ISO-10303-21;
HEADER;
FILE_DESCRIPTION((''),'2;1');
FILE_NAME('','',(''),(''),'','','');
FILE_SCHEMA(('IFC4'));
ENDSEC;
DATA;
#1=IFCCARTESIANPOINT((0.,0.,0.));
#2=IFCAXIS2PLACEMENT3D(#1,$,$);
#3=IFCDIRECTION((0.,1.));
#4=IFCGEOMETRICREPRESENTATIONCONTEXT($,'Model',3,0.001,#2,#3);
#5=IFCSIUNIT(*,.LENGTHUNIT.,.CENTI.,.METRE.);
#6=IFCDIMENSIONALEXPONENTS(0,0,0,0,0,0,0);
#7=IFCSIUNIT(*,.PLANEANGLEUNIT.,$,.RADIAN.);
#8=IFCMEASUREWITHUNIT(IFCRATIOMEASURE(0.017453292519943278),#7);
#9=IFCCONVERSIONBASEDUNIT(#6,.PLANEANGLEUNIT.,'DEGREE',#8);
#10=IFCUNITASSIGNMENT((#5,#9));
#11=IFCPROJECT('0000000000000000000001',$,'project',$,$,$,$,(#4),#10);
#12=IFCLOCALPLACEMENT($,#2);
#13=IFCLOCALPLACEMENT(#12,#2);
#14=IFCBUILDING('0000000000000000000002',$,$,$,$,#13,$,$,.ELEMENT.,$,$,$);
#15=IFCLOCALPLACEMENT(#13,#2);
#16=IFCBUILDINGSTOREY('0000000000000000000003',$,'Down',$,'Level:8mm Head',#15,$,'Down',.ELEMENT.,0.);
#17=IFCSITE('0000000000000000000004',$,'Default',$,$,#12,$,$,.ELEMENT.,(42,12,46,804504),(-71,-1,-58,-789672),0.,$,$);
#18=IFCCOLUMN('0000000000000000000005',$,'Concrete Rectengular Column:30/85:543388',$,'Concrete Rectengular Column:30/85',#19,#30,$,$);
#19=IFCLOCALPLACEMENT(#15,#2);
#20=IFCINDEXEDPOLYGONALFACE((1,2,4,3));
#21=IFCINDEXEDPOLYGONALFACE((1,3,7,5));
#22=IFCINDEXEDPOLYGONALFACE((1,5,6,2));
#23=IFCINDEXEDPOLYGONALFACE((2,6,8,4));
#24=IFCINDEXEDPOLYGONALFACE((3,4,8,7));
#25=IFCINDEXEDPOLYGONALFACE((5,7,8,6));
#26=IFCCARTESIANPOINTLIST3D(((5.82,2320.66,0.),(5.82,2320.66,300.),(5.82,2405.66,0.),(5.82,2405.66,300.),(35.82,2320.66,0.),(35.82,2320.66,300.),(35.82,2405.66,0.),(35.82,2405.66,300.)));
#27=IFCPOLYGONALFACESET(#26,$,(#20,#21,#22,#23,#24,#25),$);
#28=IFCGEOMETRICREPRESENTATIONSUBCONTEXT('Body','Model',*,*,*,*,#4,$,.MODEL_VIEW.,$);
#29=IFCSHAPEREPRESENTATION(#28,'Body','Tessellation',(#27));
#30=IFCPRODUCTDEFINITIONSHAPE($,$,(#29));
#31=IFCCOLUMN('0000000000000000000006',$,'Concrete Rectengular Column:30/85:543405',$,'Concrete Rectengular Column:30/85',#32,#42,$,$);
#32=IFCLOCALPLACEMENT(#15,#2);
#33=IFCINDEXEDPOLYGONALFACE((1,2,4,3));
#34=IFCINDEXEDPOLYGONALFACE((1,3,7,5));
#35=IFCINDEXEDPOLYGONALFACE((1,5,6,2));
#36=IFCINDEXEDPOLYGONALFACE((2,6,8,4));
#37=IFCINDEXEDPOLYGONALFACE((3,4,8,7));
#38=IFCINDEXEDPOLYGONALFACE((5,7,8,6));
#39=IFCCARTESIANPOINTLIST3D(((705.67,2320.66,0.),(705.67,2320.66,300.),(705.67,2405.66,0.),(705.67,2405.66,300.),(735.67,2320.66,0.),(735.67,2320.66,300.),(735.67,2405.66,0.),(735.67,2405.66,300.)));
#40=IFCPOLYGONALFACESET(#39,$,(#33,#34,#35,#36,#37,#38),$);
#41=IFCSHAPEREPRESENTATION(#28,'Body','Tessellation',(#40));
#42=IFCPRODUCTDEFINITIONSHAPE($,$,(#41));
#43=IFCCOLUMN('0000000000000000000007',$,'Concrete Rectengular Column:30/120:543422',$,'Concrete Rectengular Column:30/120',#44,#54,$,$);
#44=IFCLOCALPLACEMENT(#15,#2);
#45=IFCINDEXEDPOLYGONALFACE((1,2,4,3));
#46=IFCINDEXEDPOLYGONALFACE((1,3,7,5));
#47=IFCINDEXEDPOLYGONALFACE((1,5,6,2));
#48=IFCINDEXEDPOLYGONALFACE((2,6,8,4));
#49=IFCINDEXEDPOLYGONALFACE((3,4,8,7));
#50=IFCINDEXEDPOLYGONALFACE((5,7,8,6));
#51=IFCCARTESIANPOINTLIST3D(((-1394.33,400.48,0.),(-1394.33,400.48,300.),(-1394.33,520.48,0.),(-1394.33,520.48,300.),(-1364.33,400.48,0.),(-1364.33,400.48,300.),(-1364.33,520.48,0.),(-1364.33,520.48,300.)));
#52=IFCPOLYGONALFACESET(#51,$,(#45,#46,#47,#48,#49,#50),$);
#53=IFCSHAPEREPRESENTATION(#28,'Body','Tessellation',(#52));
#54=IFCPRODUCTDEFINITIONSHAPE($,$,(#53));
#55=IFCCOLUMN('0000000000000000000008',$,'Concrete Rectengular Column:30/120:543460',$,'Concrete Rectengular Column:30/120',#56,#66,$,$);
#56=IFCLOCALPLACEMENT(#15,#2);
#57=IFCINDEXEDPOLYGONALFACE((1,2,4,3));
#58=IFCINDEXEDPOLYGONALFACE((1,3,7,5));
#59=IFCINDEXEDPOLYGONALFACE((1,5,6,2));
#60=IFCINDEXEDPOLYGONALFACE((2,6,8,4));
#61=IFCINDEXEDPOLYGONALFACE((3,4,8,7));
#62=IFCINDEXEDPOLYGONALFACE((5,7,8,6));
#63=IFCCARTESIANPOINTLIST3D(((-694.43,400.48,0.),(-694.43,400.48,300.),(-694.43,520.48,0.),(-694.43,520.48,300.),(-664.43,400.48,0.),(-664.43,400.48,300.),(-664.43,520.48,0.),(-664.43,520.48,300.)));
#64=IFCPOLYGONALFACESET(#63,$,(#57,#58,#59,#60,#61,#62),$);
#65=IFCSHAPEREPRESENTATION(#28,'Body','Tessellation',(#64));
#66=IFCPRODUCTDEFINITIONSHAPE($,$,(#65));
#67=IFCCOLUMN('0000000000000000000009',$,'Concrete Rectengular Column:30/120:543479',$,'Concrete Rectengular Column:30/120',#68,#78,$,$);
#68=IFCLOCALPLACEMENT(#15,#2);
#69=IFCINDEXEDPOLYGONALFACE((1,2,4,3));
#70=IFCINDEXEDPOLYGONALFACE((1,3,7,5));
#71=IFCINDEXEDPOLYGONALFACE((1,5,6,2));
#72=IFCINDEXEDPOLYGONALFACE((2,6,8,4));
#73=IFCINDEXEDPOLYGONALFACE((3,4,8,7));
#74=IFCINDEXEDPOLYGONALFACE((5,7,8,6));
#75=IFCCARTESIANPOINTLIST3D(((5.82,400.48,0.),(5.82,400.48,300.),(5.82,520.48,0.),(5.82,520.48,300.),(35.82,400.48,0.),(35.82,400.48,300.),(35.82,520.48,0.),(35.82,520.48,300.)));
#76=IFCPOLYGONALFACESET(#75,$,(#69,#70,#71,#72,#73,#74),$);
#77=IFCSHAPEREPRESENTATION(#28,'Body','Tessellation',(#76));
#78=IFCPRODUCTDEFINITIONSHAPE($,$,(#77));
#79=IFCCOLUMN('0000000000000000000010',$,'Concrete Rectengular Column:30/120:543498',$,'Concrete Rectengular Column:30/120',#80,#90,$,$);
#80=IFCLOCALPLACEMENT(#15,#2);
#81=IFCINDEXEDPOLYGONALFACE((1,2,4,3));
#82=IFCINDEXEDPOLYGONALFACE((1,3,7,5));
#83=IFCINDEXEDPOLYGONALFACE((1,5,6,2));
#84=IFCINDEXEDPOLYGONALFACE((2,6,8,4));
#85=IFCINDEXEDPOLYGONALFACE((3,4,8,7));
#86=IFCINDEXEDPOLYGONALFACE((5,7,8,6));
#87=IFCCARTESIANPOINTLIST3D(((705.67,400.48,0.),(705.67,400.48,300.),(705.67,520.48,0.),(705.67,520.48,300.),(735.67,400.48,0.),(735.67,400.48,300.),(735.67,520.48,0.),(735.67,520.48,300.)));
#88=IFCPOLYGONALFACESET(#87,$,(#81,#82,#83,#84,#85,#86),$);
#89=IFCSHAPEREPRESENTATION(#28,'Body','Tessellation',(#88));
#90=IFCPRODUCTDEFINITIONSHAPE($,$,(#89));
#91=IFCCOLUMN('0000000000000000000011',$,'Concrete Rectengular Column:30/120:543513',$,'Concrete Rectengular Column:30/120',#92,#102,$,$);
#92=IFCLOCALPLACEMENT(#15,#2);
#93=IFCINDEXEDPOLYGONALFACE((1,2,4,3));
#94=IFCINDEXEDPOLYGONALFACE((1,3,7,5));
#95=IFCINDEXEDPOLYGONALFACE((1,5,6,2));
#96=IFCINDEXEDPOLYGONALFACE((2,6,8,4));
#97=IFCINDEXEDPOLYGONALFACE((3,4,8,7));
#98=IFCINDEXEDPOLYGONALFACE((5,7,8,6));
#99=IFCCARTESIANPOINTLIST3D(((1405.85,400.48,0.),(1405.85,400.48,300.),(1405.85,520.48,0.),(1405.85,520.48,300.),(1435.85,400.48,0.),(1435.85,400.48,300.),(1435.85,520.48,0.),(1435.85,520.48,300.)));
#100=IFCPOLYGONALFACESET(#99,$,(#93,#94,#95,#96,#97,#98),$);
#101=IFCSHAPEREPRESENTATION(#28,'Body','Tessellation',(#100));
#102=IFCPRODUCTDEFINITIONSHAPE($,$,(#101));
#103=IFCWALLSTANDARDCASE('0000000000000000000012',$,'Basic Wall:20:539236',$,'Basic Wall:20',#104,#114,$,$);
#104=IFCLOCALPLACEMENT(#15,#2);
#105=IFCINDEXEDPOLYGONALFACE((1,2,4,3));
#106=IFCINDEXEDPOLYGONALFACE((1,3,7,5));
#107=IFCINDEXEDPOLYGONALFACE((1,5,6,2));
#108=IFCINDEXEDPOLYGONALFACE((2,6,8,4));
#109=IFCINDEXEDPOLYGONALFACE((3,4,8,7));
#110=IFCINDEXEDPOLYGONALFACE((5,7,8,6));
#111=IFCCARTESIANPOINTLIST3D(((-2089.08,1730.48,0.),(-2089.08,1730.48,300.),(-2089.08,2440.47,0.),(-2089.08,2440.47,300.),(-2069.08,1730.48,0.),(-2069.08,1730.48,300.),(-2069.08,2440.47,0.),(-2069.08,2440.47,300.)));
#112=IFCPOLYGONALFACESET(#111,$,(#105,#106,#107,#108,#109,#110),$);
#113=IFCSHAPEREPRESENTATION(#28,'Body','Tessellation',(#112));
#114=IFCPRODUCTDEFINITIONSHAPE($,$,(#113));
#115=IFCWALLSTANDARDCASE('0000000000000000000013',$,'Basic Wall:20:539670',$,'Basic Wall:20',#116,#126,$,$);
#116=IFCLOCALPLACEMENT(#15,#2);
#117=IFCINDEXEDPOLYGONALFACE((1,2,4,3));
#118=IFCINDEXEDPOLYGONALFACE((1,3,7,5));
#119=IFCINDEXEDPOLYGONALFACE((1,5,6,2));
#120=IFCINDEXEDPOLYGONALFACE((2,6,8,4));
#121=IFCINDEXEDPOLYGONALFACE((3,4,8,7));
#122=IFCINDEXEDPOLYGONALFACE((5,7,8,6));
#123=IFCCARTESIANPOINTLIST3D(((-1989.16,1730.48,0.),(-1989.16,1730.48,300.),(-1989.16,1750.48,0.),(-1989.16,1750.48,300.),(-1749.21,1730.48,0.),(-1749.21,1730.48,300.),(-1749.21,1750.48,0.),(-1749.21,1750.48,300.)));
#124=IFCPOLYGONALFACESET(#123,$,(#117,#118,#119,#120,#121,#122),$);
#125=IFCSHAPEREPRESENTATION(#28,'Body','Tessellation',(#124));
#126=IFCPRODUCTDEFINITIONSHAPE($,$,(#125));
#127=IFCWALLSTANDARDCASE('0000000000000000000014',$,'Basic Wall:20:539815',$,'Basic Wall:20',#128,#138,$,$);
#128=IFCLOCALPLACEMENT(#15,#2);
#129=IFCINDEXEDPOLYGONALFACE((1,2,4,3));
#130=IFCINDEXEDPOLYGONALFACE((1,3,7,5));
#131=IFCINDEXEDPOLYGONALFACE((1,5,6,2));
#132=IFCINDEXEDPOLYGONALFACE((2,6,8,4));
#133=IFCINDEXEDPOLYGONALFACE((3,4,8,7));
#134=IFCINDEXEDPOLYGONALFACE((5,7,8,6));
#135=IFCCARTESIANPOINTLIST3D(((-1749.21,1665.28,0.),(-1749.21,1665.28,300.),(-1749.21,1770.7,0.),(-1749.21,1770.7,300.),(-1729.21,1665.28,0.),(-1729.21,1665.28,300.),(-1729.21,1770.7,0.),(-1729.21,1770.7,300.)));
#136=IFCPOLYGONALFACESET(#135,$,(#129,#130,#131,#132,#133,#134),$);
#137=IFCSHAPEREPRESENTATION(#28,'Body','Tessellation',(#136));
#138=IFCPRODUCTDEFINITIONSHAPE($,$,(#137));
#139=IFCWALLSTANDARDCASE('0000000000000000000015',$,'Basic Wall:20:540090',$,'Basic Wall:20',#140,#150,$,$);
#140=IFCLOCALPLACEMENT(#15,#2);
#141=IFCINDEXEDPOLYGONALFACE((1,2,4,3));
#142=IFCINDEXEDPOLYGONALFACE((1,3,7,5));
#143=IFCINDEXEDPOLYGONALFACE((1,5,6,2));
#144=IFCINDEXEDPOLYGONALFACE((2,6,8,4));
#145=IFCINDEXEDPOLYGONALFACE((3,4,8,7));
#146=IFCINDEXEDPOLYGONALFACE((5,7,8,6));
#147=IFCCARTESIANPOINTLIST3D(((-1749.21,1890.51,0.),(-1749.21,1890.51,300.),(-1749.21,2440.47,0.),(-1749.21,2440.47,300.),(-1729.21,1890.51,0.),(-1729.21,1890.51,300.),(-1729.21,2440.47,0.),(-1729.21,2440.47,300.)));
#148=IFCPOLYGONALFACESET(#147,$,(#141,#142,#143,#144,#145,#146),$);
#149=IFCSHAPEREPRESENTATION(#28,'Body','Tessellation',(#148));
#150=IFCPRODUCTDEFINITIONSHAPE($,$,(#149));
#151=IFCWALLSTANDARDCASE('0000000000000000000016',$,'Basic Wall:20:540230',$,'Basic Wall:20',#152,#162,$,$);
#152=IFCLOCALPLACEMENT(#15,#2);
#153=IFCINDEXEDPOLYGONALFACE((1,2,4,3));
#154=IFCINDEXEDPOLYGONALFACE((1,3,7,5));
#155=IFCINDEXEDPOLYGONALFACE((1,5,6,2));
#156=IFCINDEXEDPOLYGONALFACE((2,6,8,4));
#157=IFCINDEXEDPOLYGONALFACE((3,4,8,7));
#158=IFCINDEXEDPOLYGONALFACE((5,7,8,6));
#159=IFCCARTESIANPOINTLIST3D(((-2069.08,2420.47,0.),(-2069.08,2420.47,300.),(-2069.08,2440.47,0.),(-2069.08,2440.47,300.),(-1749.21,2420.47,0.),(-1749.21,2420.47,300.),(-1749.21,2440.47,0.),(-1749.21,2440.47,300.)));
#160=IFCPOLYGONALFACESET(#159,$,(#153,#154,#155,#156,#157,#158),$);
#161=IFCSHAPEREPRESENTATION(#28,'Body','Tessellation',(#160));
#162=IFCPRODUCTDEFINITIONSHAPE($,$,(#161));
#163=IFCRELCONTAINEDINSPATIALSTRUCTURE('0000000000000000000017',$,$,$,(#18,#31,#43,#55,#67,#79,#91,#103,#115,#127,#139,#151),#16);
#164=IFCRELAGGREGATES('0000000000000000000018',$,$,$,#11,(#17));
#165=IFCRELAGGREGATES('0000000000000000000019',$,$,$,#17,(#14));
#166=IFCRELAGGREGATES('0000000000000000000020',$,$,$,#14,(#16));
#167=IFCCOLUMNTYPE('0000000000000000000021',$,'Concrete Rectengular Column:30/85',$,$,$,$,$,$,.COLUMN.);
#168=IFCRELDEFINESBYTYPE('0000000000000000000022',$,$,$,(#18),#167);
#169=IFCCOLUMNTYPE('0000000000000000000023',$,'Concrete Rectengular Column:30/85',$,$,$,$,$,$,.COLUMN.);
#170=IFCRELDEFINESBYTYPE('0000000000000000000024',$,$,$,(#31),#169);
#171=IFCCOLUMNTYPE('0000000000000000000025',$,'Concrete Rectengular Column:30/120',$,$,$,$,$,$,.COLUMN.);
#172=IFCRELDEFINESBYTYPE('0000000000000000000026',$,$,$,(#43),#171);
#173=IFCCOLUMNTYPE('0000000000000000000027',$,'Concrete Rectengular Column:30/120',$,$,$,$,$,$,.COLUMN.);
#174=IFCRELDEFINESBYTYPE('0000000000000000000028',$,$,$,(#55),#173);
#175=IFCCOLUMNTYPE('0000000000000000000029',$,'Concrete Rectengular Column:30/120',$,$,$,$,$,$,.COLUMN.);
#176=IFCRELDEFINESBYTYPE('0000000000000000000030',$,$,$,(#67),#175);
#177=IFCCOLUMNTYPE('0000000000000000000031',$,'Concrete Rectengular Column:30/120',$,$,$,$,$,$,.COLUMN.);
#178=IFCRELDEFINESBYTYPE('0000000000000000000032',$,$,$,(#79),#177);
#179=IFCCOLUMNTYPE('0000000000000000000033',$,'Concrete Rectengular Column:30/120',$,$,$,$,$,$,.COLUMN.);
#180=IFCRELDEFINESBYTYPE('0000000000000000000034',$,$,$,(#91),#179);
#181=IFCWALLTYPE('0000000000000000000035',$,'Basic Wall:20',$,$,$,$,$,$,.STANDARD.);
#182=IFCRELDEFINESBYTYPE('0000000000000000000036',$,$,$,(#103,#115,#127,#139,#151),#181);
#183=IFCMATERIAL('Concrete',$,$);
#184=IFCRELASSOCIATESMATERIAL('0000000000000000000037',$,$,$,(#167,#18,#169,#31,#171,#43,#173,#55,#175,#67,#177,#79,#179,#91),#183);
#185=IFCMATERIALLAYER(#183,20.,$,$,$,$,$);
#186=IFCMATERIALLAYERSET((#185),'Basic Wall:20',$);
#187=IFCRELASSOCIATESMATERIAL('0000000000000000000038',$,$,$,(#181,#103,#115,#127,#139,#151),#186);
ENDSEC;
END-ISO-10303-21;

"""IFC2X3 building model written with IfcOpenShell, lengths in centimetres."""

from ifc_helpers import new_model, entity, si_unit, converted_unit, direction, frame, frame_2d, origin, origin_2d_with_axis, place, context, subcontext, project, spatial, rectangle, extrude, source, transform, mapped, material, layer, layer_set, layer_usage, type_object, type_shapes, element, save


model = new_model("IFC2X3")

# Units and contexts
model_context = context("Model", 3, precision=0.001, world=origin(), true_north=direction((0.0, 1.0)))
body_context = subcontext(model_context, "Body", "Model", "MODEL_VIEW")
ifc_project = project(units=[si_unit("LENGTHUNIT", "METRE", prefix="CENTI"), converted_unit("PLANEANGLEUNIT", "DEGREE", entity("IfcRatioMeasure", 0.017453292519943278), si_unit("PLANEANGLEUNIT", "RADIAN"), dimensions=[0, 0, 0, 0, 0, 0, 0])], contexts=[model_context])

# Site, building, storey
site_placement = place(None, origin())
site = spatial("IfcSite", under=ifc_project, at=site_placement, Name="Default", CompositionType="ELEMENT", RefLatitude=(42, 12, 46, 804504), RefLongitude=(-71, -1, -58, -789672), RefElevation=0.0)
building_placement = place(site_placement, origin())
building = spatial("IfcBuilding", under=site, at=building_placement, CompositionType="ELEMENT")
storey_placement = place(building_placement, origin())
storey = spatial("IfcBuildingStorey", under=building, at=storey_placement, Name="Down", ObjectType="Level:8mm Head", LongName="Down", CompositionType="ELEMENT", Elevation=0.0)

# Columns
ifc_material = material(Name="Concrete")
column_type_1 = type_object("IfcColumnType", Name="Concrete Rectengular Column:30/85", PredefinedType="COLUMN", material=ifc_material)
shared_shape_1 = source(origin(), body_context, "Body", "SweptSolid", [
    extrude(rectangle(XDim=85.0, YDim=30.0, at=frame_2d((0.0, 0.0), x_axis=(1.0, 0.0))), frame((20.82, 2363.16, 0.0), z_axis=(0.0, 0.0, 1.0), x_axis=(0.0, -1.0, 0.0)), (0.0, 0.0, 1.0), 300.0),
])
type_shapes(column_type_1, [shared_shape_1])
column_1_placement = place(storey_placement, origin())
element("IfcColumn", 1, at=column_1_placement, inside=storey, type_object=column_type_1, material=ifc_material, Name="Concrete Rectengular Column:30/85:543388", ObjectType="Concrete Rectengular Column:30/85", context=body_context, shape_type="MappedRepresentation", body=[
    mapped(shared_shape_1, transform((0.0, 0.0, 0.0), scale=1.0)),
])
column_type_2 = type_object("IfcColumnType", Name="Concrete Rectengular Column:30/85", PredefinedType="COLUMN", material=ifc_material)
shared_shape_2 = source(origin(), body_context, "Body", "SweptSolid", [
    extrude(rectangle(XDim=85.0, YDim=30.0, at=frame_2d((0.0, 0.0), x_axis=(1.0, 0.0))), frame((720.67, 2363.16, 0.0), z_axis=(0.0, 0.0, 1.0), x_axis=(0.0, -1.0, 0.0)), (0.0, 0.0, 1.0), 300.0),
])
type_shapes(column_type_2, [shared_shape_2])
column_2_placement = place(storey_placement, origin())
element("IfcColumn", 2, at=column_2_placement, inside=storey, type_object=column_type_2, material=ifc_material, Name="Concrete Rectengular Column:30/85:543405", ObjectType="Concrete Rectengular Column:30/85", context=body_context, shape_type="MappedRepresentation", body=[
    mapped(shared_shape_2, transform((0.0, 0.0, 0.0), scale=1.0)),
])
column_type_3 = type_object("IfcColumnType", Name="Concrete Rectengular Column:30/120", PredefinedType="COLUMN", material=ifc_material)
shared_shape_3 = source(origin(), body_context, "Body", "SweptSolid", [
    extrude(rectangle(XDim=120.0, YDim=30.0, at=origin_2d_with_axis()), frame((-1379.33, 460.48, 0.0), z_axis=(0.0, 0.0, 1.0), x_axis=(0.0, -1.0, 0.0)), (0.0, 0.0, 1.0), 300.0),
])
type_shapes(column_type_3, [shared_shape_3])
column_3_placement = place(storey_placement, origin())
element("IfcColumn", 3, at=column_3_placement, inside=storey, type_object=column_type_3, material=ifc_material, Name="Concrete Rectengular Column:30/120:543422", ObjectType="Concrete Rectengular Column:30/120", context=body_context, shape_type="MappedRepresentation", body=[
    mapped(shared_shape_3, transform((0.0, 0.0, 0.0), scale=1.0)),
])
column_type_4 = type_object("IfcColumnType", Name="Concrete Rectengular Column:30/120", PredefinedType="COLUMN", material=ifc_material)
shared_shape_4 = source(origin(), body_context, "Body", "SweptSolid", [
    extrude(rectangle(XDim=120.0, YDim=30.0, at=frame_2d((0.0, 0.0), x_axis=(1.0, 0.0))), frame((-679.43, 460.48, 0.0), z_axis=(0.0, 0.0, 1.0), x_axis=(0.0, -1.0, 0.0)), (0.0, 0.0, 1.0), 300.0),
])
type_shapes(column_type_4, [shared_shape_4])
column_4_placement = place(storey_placement, origin())
element("IfcColumn", 4, at=column_4_placement, inside=storey, type_object=column_type_4, material=ifc_material, Name="Concrete Rectengular Column:30/120:543460", ObjectType="Concrete Rectengular Column:30/120", context=body_context, shape_type="MappedRepresentation", body=[
    mapped(shared_shape_4, transform((0.0, 0.0, 0.0), scale=1.0)),
])
column_type_5 = type_object("IfcColumnType", Name="Concrete Rectengular Column:30/120", PredefinedType="COLUMN", material=ifc_material)
shared_shape_5 = source(origin(), body_context, "Body", "SweptSolid", [
    extrude(rectangle(XDim=120.0, YDim=30.0, at=frame_2d((0.0, 0.0), x_axis=(1.0, 0.0))), frame((20.82, 460.48, 0.0), z_axis=(0.0, 0.0, 1.0), x_axis=(0.0, -1.0, 0.0)), (0.0, 0.0, 1.0), 300.0),
])
type_shapes(column_type_5, [shared_shape_5])
column_5_placement = place(storey_placement, origin())
element("IfcColumn", 5, at=column_5_placement, inside=storey, type_object=column_type_5, material=ifc_material, Name="Concrete Rectengular Column:30/120:543479", ObjectType="Concrete Rectengular Column:30/120", context=body_context, shape_type="MappedRepresentation", body=[
    mapped(shared_shape_5, transform((0.0, 0.0, 0.0), scale=1.0)),
])
column_type_6 = type_object("IfcColumnType", Name="Concrete Rectengular Column:30/120", PredefinedType="COLUMN", material=ifc_material)
shared_shape_6 = source(origin(), body_context, "Body", "SweptSolid", [
    extrude(rectangle(XDim=120.0, YDim=30.0, at=frame_2d((0.0, 0.0), x_axis=(1.0, 0.0))), frame((720.67, 460.48, 0.0), z_axis=(0.0, 0.0, 1.0), x_axis=(0.0, -1.0, 0.0)), (0.0, 0.0, 1.0), 300.0),
])
type_shapes(column_type_6, [shared_shape_6])
column_6_placement = place(storey_placement, origin())
element("IfcColumn", 6, at=column_6_placement, inside=storey, type_object=column_type_6, material=ifc_material, Name="Concrete Rectengular Column:30/120:543498", ObjectType="Concrete Rectengular Column:30/120", context=body_context, shape_type="MappedRepresentation", body=[
    mapped(shared_shape_6, transform((0.0, 0.0, 0.0), scale=1.0)),
])
column_type_7 = type_object("IfcColumnType", Name="Concrete Rectengular Column:30/120", PredefinedType="COLUMN", material=ifc_material)
shared_shape_7 = source(origin(), body_context, "Body", "SweptSolid", [
    extrude(rectangle(XDim=120.0, YDim=30.0, at=frame_2d((0.0, 0.0), x_axis=(1.0, 0.0))), frame((1420.85, 460.48, 0.0), z_axis=(0.0, 0.0, 1.0), x_axis=(0.0, -1.0, 0.0)), (0.0, 0.0, 1.0), 300.0),
])
type_shapes(column_type_7, [shared_shape_7])
column_7_placement = place(storey_placement, origin())
element("IfcColumn", 7, at=column_7_placement, inside=storey, type_object=column_type_7, material=ifc_material, Name="Concrete Rectengular Column:30/120:543513", ObjectType="Concrete Rectengular Column:30/120", context=body_context, shape_type="MappedRepresentation", body=[
    mapped(shared_shape_7, transform((0.0, 0.0, 0.0), scale=1.0)),
])

# Walls
ifc_layer_1 = layer(ifc_material, 20.0)
ifc_layer_set_1 = layer_set([ifc_layer_1], Name="Basic Wall:20")
ifc_layer_usage_1 = layer_usage(ifc_layer_set_1, "AXIS2", "POSITIVE", -10.0)
wall_type_1 = type_object("IfcWallType", Name="Basic Wall:20", PredefinedType="STANDARD", material=ifc_layer_set_1)
wall_1_placement = place(storey_placement, frame((-2079.08, 2440.47, 0.0), z_axis=(0.0, 0.0, 1.0), x_axis=(0.0, -1.0, 0.0)))
element("IfcWallStandardCase", 8, at=wall_1_placement, inside=storey, type_object=wall_type_1, material=ifc_layer_usage_1, Name="Basic Wall:20:539236", ObjectType="Basic Wall:20", context=body_context, shape_type="SweptSolid", body=[
    extrude(rectangle(XDim=709.99, YDim=20.0, at=frame_2d((355.0, 0.0), x_axis=(-1.0, 0.0))), origin(), (0.0, 0.0, 1.0), 300.0),
])
ifc_layer_usage_2 = layer_usage(ifc_layer_set_1, "AXIS2", "POSITIVE", -10.0)
wall_2_placement = place(storey_placement, frame((-1989.16, 1740.48, 0.0)))
element("IfcWallStandardCase", 9, at=wall_2_placement, inside=storey, type_object=wall_type_1, material=ifc_layer_usage_2, Name="Basic Wall:20:539670", ObjectType="Basic Wall:20", context=body_context, shape_type="SweptSolid", body=[
    extrude(rectangle(XDim=239.95, YDim=20.0, at=frame_2d((119.98, 0.0), x_axis=(-1.0, 0.0))), origin(), (0.0, 0.0, 1.0), 300.0),
])
ifc_layer_usage_3 = layer_usage(ifc_layer_set_1, "AXIS2", "NEGATIVE", 10.0)
wall_3_placement = place(storey_placement, frame((-1739.21, 1770.7, 0.0), z_axis=(0.0, 0.0, 1.0), x_axis=(0.0, -1.0, 0.0)))
element("IfcWallStandardCase", 10, at=wall_3_placement, inside=storey, type_object=wall_type_1, material=ifc_layer_usage_3, Name="Basic Wall:20:539815", ObjectType="Basic Wall:20", context=body_context, shape_type="SweptSolid", body=[
    extrude(rectangle(XDim=105.42, YDim=20.0, at=frame_2d((52.71, 0.0), x_axis=(-1.0, 0.0))), origin(), (0.0, 0.0, 1.0), 300.0),
])
ifc_layer_usage_4 = layer_usage(ifc_layer_set_1, "AXIS2", "POSITIVE", -10.0)
wall_4_placement = place(storey_placement, frame((-1739.21, 1890.51, 0.0), z_axis=(0.0, 0.0, 1.0), x_axis=(0.0, 1.0, 0.0)))
element("IfcWallStandardCase", 11, at=wall_4_placement, inside=storey, type_object=wall_type_1, material=ifc_layer_usage_4, Name="Basic Wall:20:540090", ObjectType="Basic Wall:20", context=body_context, shape_type="SweptSolid", body=[
    extrude(rectangle(XDim=549.96, YDim=20.0, at=frame_2d((274.98, 0.0), x_axis=(-1.0, 0.0))), origin(), (0.0, 0.0, 1.0), 300.0),
])
ifc_layer_usage_5 = layer_usage(ifc_layer_set_1, "AXIS2", "POSITIVE", -10.0)
wall_5_placement = place(storey_placement, frame((-1749.21, 2430.47, 0.0), z_axis=(0.0, 0.0, 1.0), x_axis=(-1.0, 0.0, 0.0)))
element("IfcWallStandardCase", 12, at=wall_5_placement, inside=storey, type_object=wall_type_1, material=ifc_layer_usage_5, Name="Basic Wall:20:540230", ObjectType="Basic Wall:20", context=body_context, shape_type="SweptSolid", body=[
    extrude(rectangle(XDim=319.87, YDim=20.0, at=frame_2d((159.93, 0.0), x_axis=(-1.0, 0.0))), origin(), (0.0, 0.0, 1.0), 300.0),
])

save(model, "model.ifc")
